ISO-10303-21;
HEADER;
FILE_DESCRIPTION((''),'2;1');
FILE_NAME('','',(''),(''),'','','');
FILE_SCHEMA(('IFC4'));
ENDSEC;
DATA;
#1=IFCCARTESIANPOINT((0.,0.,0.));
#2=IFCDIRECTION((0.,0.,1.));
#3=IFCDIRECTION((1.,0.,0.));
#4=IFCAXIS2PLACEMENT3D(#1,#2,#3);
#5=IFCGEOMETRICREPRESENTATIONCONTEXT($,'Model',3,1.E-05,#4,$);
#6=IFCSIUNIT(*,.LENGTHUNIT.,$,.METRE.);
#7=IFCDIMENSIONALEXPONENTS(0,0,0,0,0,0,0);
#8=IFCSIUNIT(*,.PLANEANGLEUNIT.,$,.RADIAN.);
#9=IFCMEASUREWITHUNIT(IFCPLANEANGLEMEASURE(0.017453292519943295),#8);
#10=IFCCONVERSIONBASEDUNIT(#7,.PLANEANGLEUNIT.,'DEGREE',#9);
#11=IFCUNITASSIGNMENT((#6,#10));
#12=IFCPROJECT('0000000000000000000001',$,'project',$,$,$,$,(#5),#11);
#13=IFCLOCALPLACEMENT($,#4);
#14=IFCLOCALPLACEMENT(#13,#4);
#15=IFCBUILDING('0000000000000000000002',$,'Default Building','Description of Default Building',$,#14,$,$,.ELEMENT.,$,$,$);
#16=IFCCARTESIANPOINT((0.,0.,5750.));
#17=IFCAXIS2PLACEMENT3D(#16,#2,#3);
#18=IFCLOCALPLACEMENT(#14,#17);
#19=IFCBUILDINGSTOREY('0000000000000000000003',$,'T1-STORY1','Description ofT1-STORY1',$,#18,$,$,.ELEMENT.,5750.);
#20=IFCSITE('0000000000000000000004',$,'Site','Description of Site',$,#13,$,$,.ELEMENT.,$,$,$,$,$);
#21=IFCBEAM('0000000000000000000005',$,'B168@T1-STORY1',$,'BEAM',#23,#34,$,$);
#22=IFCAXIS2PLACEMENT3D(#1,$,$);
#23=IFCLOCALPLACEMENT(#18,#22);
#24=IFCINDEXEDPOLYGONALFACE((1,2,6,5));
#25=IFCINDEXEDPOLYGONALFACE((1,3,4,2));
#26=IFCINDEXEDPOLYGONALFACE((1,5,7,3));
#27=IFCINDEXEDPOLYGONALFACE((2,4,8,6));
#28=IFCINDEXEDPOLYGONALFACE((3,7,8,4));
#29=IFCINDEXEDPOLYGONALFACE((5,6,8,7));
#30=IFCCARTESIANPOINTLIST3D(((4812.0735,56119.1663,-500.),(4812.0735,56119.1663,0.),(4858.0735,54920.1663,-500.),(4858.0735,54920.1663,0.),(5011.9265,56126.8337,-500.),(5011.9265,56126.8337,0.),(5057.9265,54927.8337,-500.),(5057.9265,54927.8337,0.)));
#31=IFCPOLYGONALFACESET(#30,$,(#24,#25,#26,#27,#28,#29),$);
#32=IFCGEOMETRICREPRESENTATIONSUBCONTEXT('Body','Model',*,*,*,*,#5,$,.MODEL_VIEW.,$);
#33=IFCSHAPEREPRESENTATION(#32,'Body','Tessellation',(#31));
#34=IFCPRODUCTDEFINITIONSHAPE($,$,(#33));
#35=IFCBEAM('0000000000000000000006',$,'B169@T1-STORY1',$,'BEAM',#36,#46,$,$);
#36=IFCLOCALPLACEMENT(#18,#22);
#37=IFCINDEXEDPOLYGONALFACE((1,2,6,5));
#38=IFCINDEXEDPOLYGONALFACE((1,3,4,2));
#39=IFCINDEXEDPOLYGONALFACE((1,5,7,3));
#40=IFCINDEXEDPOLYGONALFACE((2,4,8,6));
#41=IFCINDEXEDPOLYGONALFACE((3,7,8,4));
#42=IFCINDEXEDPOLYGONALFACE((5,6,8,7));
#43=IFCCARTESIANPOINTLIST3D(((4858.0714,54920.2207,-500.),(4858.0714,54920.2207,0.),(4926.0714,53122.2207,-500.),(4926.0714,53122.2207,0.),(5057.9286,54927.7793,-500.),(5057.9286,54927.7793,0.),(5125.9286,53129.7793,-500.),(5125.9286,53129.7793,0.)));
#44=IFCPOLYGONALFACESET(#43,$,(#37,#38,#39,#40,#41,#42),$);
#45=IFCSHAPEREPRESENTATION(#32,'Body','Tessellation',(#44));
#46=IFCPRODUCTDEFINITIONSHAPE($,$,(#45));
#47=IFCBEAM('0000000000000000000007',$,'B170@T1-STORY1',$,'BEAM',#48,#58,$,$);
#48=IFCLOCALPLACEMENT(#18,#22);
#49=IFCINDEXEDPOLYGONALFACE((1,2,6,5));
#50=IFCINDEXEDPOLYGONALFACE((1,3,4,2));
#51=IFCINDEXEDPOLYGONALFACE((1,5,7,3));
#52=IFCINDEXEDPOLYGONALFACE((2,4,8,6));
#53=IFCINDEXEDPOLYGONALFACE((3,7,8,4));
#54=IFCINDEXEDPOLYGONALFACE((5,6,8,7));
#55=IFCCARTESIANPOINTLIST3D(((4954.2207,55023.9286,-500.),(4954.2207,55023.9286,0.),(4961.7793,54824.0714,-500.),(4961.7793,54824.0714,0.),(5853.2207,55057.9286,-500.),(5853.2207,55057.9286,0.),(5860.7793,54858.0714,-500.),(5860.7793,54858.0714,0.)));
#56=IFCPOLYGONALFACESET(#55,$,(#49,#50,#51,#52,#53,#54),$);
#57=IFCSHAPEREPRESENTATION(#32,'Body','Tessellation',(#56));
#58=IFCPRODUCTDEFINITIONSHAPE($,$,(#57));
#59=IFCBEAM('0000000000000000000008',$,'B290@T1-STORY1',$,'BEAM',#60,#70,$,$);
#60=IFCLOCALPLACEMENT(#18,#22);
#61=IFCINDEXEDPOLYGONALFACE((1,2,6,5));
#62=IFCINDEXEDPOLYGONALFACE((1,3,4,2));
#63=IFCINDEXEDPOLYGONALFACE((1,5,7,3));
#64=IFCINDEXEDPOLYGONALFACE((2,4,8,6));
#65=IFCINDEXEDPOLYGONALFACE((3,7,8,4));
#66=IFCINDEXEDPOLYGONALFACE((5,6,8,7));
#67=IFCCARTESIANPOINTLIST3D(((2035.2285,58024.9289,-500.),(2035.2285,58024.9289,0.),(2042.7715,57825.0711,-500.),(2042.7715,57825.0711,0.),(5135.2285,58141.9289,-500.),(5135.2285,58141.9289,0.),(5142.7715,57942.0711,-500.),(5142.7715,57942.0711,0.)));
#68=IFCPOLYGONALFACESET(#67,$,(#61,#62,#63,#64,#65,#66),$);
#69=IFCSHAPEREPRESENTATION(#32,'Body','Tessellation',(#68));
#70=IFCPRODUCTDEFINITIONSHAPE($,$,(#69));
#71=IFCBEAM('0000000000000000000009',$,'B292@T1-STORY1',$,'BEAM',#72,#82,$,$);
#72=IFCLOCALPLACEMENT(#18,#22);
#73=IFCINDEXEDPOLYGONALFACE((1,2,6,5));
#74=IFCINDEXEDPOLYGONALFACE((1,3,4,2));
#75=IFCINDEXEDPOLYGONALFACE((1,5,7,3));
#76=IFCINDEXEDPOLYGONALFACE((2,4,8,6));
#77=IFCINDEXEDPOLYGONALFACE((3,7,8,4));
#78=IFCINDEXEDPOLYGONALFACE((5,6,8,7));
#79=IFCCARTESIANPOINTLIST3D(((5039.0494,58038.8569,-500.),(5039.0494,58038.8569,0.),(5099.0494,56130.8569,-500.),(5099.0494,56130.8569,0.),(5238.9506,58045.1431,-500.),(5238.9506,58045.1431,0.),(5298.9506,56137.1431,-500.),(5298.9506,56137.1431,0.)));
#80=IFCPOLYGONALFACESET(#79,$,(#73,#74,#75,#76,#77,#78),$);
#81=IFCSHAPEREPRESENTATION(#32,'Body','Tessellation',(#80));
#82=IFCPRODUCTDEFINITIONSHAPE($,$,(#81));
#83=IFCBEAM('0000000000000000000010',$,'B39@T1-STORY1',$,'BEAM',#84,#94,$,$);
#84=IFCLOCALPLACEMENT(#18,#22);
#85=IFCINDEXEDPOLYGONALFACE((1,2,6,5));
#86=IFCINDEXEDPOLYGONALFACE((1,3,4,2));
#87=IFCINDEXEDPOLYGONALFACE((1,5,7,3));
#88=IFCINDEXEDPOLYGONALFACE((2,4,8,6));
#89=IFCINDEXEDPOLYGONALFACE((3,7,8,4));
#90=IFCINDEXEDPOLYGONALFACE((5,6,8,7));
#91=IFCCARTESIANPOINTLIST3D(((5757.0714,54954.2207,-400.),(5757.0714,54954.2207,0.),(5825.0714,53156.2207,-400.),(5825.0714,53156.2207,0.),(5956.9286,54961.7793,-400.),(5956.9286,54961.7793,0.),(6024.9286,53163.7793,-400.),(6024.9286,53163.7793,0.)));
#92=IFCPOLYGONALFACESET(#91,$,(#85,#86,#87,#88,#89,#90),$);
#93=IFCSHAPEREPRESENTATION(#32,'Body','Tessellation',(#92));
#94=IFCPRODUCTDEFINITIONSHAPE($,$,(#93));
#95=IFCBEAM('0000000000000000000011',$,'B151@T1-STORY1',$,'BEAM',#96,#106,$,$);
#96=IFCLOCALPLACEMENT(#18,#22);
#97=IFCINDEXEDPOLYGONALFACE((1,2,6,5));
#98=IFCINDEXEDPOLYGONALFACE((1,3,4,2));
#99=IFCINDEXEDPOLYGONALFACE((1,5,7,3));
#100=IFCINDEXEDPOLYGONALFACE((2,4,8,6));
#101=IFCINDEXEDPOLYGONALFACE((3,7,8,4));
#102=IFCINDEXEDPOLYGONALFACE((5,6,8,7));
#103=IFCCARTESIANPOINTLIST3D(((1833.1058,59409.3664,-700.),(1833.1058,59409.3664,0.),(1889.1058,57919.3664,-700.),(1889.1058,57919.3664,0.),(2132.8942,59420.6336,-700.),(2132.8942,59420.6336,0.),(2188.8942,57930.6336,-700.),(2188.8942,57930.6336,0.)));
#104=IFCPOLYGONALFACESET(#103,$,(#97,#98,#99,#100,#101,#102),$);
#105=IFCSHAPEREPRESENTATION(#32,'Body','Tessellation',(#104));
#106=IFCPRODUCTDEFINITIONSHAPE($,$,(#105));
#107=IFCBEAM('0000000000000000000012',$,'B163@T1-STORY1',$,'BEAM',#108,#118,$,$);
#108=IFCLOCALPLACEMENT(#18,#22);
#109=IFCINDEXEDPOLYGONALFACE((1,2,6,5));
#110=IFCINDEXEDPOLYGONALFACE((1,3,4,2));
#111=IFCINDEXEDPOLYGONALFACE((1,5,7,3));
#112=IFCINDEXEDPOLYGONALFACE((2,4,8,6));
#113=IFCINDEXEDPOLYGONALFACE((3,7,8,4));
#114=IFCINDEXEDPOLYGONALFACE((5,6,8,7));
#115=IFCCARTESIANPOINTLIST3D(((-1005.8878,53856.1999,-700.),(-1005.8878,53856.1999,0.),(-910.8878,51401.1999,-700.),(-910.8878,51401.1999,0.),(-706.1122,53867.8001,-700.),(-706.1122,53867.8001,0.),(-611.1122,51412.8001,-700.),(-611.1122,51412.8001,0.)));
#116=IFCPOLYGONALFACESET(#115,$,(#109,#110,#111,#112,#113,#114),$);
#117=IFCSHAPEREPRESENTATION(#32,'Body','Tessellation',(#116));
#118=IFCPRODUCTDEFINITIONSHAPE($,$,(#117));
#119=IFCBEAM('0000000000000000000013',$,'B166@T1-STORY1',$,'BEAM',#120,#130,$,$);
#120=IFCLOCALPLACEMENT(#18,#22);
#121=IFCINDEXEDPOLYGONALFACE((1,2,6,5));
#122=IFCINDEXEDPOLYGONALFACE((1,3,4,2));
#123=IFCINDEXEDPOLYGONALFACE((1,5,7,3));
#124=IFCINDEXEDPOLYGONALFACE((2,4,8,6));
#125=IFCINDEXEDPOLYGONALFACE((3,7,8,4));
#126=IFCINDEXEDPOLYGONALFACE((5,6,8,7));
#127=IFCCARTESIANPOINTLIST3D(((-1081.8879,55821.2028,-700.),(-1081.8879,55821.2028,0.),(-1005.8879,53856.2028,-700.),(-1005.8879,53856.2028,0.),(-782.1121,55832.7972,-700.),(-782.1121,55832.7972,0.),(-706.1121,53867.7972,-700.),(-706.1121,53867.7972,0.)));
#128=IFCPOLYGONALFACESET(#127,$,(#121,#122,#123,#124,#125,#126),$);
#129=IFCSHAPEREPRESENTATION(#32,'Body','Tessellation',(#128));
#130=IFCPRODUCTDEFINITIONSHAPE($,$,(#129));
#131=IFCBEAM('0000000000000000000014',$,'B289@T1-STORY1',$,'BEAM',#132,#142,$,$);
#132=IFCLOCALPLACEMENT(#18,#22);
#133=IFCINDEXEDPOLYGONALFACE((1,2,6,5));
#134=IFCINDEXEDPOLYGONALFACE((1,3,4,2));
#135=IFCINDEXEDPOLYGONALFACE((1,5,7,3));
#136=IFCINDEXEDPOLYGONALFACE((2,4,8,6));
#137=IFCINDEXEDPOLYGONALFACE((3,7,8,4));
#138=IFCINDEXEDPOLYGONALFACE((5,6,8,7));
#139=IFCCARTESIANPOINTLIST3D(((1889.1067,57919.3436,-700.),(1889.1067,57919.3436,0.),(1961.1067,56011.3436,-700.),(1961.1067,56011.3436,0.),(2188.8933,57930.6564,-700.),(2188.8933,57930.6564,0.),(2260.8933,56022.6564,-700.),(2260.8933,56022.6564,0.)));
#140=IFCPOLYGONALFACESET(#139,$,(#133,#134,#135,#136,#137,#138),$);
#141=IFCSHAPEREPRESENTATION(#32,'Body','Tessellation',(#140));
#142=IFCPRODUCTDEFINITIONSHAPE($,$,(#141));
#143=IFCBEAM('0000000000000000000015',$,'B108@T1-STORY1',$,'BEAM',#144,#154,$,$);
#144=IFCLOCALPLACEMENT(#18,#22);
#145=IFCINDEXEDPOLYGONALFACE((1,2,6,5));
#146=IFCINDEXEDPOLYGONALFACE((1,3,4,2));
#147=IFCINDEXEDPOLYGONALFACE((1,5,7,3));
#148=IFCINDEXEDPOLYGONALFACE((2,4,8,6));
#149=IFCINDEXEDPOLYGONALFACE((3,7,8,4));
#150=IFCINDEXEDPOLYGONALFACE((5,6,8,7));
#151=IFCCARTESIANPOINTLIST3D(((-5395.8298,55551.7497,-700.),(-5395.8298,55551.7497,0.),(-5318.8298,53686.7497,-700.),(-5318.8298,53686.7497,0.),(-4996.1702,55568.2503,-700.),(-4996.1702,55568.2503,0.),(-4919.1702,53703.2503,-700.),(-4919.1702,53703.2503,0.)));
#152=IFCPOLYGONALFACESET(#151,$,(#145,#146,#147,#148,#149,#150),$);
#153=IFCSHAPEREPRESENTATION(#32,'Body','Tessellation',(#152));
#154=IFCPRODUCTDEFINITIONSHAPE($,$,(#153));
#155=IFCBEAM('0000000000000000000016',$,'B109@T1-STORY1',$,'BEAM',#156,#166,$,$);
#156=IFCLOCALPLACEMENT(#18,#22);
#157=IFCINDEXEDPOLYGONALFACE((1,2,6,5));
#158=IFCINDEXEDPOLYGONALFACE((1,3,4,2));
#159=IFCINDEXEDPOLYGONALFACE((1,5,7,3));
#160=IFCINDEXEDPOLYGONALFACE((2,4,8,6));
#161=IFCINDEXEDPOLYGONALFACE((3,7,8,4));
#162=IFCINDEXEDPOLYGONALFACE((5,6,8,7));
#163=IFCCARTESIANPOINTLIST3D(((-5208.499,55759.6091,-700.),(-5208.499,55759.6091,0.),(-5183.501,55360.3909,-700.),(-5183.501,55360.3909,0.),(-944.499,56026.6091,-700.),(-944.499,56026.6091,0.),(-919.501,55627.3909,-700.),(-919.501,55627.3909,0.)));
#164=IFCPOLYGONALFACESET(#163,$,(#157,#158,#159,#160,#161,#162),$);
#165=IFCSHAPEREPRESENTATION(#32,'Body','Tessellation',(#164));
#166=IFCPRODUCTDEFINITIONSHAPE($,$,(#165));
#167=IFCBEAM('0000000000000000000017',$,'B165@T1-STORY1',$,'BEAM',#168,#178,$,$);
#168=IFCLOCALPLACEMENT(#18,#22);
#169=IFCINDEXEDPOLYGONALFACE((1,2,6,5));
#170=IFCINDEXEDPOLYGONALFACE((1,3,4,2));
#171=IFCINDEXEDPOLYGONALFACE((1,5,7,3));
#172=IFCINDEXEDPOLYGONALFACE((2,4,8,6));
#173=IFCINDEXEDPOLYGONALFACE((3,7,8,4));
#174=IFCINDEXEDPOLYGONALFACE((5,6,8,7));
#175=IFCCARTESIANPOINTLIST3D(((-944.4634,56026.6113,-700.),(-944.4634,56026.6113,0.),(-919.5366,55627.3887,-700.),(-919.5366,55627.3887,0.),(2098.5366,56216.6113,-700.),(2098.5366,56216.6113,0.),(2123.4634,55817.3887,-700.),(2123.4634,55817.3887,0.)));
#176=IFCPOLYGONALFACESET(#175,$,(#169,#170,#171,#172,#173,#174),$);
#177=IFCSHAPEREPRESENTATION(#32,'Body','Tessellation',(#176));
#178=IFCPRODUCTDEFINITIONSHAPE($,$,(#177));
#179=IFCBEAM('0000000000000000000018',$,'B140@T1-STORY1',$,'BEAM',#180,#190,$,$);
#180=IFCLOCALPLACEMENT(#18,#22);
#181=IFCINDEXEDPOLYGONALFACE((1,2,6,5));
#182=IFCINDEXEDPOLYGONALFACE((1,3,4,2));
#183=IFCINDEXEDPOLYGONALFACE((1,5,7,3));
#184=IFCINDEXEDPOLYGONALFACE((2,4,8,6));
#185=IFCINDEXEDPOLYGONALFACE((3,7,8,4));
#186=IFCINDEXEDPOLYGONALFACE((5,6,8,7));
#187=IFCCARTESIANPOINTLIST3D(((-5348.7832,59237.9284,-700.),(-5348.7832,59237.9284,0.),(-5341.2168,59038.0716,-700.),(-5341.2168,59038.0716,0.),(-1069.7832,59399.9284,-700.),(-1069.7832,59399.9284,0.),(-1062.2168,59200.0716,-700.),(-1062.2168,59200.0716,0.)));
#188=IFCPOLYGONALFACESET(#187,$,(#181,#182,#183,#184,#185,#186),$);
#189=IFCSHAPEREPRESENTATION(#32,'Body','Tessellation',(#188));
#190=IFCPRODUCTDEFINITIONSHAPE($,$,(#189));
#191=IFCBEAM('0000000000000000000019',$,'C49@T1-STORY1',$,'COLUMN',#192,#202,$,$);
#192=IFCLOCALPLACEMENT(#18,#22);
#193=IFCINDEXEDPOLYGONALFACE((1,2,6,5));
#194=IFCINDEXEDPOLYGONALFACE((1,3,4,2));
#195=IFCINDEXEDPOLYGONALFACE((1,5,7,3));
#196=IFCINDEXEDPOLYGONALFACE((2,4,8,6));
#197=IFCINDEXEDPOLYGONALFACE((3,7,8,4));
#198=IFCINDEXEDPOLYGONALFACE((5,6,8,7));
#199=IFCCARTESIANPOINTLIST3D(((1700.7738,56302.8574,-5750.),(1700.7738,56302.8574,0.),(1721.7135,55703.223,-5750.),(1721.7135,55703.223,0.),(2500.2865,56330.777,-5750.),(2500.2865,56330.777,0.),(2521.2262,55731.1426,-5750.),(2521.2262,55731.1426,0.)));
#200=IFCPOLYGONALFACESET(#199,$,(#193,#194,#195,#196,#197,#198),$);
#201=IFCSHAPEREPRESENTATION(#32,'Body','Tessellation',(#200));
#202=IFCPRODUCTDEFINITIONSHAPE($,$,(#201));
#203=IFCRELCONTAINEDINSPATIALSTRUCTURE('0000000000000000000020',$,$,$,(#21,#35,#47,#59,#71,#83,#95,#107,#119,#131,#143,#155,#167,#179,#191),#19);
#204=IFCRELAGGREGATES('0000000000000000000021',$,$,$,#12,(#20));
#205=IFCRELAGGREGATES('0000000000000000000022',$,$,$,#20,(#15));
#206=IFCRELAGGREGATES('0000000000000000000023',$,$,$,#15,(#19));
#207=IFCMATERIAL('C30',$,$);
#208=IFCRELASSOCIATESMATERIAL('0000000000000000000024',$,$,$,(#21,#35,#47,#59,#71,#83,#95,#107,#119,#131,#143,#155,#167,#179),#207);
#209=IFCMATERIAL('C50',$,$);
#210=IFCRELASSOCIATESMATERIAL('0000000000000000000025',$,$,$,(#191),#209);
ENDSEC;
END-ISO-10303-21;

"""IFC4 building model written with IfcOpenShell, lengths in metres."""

from ifc_helpers import new_model, entity, si_unit, converted_unit, frame, origin_with_axes, place, context, subcontext, project, spatial, rectangle, extrude, material, element, save


model = new_model("IFC4")

# Units and contexts
model_context = context("Model", 3, precision=1e-05, world=origin_with_axes())
body_context = subcontext(model_context, "Body", "Model", "MODEL_VIEW")
ifc_project = project(units=[si_unit("LENGTHUNIT", "METRE"), converted_unit("PLANEANGLEUNIT", "DEGREE", entity("IfcPlaneAngleMeasure", 0.017453292519943295), si_unit("PLANEANGLEUNIT", "RADIAN"), dimensions=[0, 0, 0, 0, 0, 0, 0])], contexts=[model_context])

# Site, building, storey
site_placement = place(None, origin_with_axes())
site = spatial("IfcSite", under=ifc_project, at=site_placement, Name="Site", Description="Description of Site", CompositionType="ELEMENT")
building_placement = place(site_placement, origin_with_axes())
building = spatial("IfcBuilding", under=site, at=building_placement, Name="Default Building", Description="Description of Default Building", CompositionType="ELEMENT")
storey_placement = place(building_placement, frame((0.0, 0.0, 5750.0), z_axis=(0.0, 0.0, 1.0), x_axis=(1.0, 0.0, 0.0)))
storey = spatial("IfcBuildingStorey", under=building, at=storey_placement, Name="T1-STORY1", Description="Description ofT1-STORY1", CompositionType="ELEMENT", Elevation=5750.0)

# Beams
ifc_material_1 = material(Name="C30")
beam_1_placement = place(storey_placement, frame((4912.0, 56123.0, -250.0), z_axis=(0.038337, -0.999265, 0.0), x_axis=(0.999265, 0.038337, 0.0)))
element("IfcBeam", 1, at=beam_1_placement, inside=storey, material=ifc_material_1, Name="B168@T1-STORY1", ObjectType="BEAM", context=body_context, shape_type="SweptSolid", body=[
    extrude(rectangle(XDim=200.0, YDim=500.0), origin_with_axes(), (0.0, 0.0, 1.0), 1199.8821),
])
beam_2_placement = place(storey_placement, frame((4958.0, 54924.0, -250.0), z_axis=(0.037793, -0.999286, 0.0), x_axis=(0.999286, 0.037793, 0.0)))
element("IfcBeam", 2, at=beam_2_placement, inside=storey, material=ifc_material_1, Name="B169@T1-STORY1", ObjectType="BEAM", context=body_context, shape_type="SweptSolid", body=[
    extrude(rectangle(XDim=200.0, YDim=500.0), origin_with_axes(), (0.0, 0.0, 1.0), 1799.2854),
])
beam_3_placement = place(storey_placement, frame((4958.0, 54924.0, -250.0), z_axis=(0.999286, 0.037793, 0.0), x_axis=(-0.037793, 0.999286, 0.0)))
element("IfcBeam", 3, at=beam_3_placement, inside=storey, material=ifc_material_1, Name="B170@T1-STORY1", ObjectType="BEAM", context=body_context, shape_type="SweptSolid", body=[
    extrude(rectangle(XDim=200.0, YDim=500.0), origin_with_axes(), (0.0, 0.0, 1.0), 899.6427),
])
beam_4_placement = place(storey_placement, frame((2039.0, 57925.0, -250.0), z_axis=(0.999289, 0.037715, 0.0), x_axis=(-0.037715, 0.999289, 0.0)))
element("IfcBeam", 4, at=beam_4_placement, inside=storey, material=ifc_material_1, Name="B290@T1-STORY1", ObjectType="BEAM", context=body_context, shape_type="SweptSolid", body=[
    extrude(rectangle(XDim=200.0, YDim=500.0), origin_with_axes(), (0.0, 0.0, 1.0), 3102.2071),
])
beam_5_placement = place(storey_placement, frame((5139.0, 58042.0, -250.0), z_axis=(0.031431, -0.999506, 0.0), x_axis=(0.999506, 0.031431, 0.0)))
element("IfcBeam", 5, at=beam_5_placement, inside=storey, material=ifc_material_1, Name="B292@T1-STORY1", ObjectType="BEAM", context=body_context, shape_type="SweptSolid", body=[
    extrude(rectangle(XDim=200.0, YDim=500.0), origin_with_axes(), (0.0, 0.0, 1.0), 1908.9432),
])
beam_6_placement = place(storey_placement, frame((5857.0, 54958.0, -200.0), z_axis=(0.037793, -0.999286, 0.0), x_axis=(0.999286, 0.037793, 0.0)))
element("IfcBeam", 6, at=beam_6_placement, inside=storey, material=ifc_material_1, Name="B39@T1-STORY1", ObjectType="BEAM", context=body_context, shape_type="SweptSolid", body=[
    extrude(rectangle(XDim=200.0, YDim=400.0), origin_with_axes(), (0.0, 0.0, 1.0), 1799.2854),
])
beam_7_placement = place(storey_placement, frame((1983.0, 59415.0, -350.0), z_axis=(0.037557, -0.999294, 0.0), x_axis=(0.999294, 0.037557, 0.0)))
element("IfcBeam", 7, at=beam_7_placement, inside=storey, material=ifc_material_1, Name="B151@T1-STORY1", ObjectType="BEAM", context=body_context, shape_type="SweptSolid", body=[
    extrude(rectangle(XDim=300.0, YDim=700.0), origin_with_axes(), (0.0, 0.0, 1.0), 1491.052),
])
beam_8_placement = place(storey_placement, frame((-856.0, 53862.0, -350.0), z_axis=(0.038668, -0.999252, 0.0), x_axis=(0.999252, 0.038668, 0.0)))
element("IfcBeam", 8, at=beam_8_placement, inside=storey, material=ifc_material_1, Name="B163@T1-STORY1", ObjectType="BEAM", context=body_context, shape_type="SweptSolid", body=[
    extrude(rectangle(XDim=300.0, YDim=700.0), origin_with_axes(), (0.0, 0.0, 1.0), 2456.8374),
])
beam_9_placement = place(storey_placement, frame((-932.0, 55827.0, -350.0), z_axis=(0.038648, -0.999253, 0.0), x_axis=(0.999253, 0.038648, 0.0)))
element("IfcBeam", 9, at=beam_9_placement, inside=storey, material=ifc_material_1, Name="B166@T1-STORY1", ObjectType="BEAM", context=body_context, shape_type="SweptSolid", body=[
    extrude(rectangle(XDim=300.0, YDim=700.0), origin_with_axes(), (0.0, 0.0, 1.0), 1966.4692),
])
beam_10_placement = place(storey_placement, frame((2039.0, 57925.0, -350.0), z_axis=(0.037709, -0.999289, 0.0), x_axis=(0.999289, 0.037709, 0.0)))
element("IfcBeam", 10, at=beam_10_placement, inside=storey, material=ifc_material_1, Name="B289@T1-STORY1", ObjectType="BEAM", context=body_context, shape_type="SweptSolid", body=[
    extrude(rectangle(XDim=300.0, YDim=700.0), origin_with_axes(), (0.0, 0.0, 1.0), 1909.358),
])
beam_11_placement = place(storey_placement, frame((-5196.0, 55560.0, -350.0), z_axis=(0.041252, -0.999149, 0.0), x_axis=(0.999149, 0.041252, 0.0)))
element("IfcBeam", 11, at=beam_11_placement, inside=storey, material=ifc_material_1, Name="B108@T1-STORY1", ObjectType="BEAM", context=body_context, shape_type="SweptSolid", body=[
    extrude(rectangle(XDim=400.0, YDim=700.0), origin_with_axes(), (0.0, 0.0, 1.0), 1866.5889),
])
beam_12_placement = place(storey_placement, frame((-5196.0, 55560.0, -350.0), z_axis=(0.998045, 0.062495, 0.0), x_axis=(-0.062495, 0.998045, 0.0)))
element("IfcBeam", 12, at=beam_12_placement, inside=storey, material=ifc_material_1, Name="B109@T1-STORY1", ObjectType="BEAM", context=body_context, shape_type="SweptSolid", body=[
    extrude(rectangle(XDim=400.0, YDim=700.0), origin_with_axes(), (0.0, 0.0, 1.0), 4272.3512),
])
beam_13_placement = place(storey_placement, frame((-932.0, 55827.0, -350.0), z_axis=(0.998056, 0.062317, 0.0), x_axis=(-0.062317, 0.998056, 0.0)))
element("IfcBeam", 13, at=beam_13_placement, inside=storey, material=ifc_material_1, Name="B165@T1-STORY1", ObjectType="BEAM", context=body_context, shape_type="SweptSolid", body=[
    extrude(rectangle(XDim=400.0, YDim=700.0), origin_with_axes(), (0.0, 0.0, 1.0), 3048.9259),
])
beam_14_placement = place(storey_placement, frame((-5345.0, 59138.0, -350.0), z_axis=(0.999284, 0.037832, 0.0), x_axis=(-0.037832, 0.999284, 0.0)))
element("IfcBeam", 14, at=beam_14_placement, inside=storey, material=ifc_material_1, Name="B140@T1-STORY1", ObjectType="BEAM", context=body_context, shape_type="SweptSolid", body=[
    extrude(rectangle(XDim=200.0, YDim=700.0), origin_with_axes(), (0.0, 0.0, 1.0), 4282.0655),
])
ifc_material_2 = material(Name="C50")
beam_15_placement = place(storey_placement, frame((2111.0, 56017.0, -5750.0), z_axis=(0.0, 0.0, 1.0), x_axis=(-0.999391, -0.034899, 0.0)))
element("IfcBeam", 15, at=beam_15_placement, inside=storey, material=ifc_material_2, Name="C49@T1-STORY1", ObjectType="COLUMN", context=body_context, shape_type="SweptSolid", body=[
    extrude(rectangle(XDim=800.0, YDim=600.0), origin_with_axes(), (0.0, 0.0, 1.0), 5750.0),
])

save(model, "model.ifc")
